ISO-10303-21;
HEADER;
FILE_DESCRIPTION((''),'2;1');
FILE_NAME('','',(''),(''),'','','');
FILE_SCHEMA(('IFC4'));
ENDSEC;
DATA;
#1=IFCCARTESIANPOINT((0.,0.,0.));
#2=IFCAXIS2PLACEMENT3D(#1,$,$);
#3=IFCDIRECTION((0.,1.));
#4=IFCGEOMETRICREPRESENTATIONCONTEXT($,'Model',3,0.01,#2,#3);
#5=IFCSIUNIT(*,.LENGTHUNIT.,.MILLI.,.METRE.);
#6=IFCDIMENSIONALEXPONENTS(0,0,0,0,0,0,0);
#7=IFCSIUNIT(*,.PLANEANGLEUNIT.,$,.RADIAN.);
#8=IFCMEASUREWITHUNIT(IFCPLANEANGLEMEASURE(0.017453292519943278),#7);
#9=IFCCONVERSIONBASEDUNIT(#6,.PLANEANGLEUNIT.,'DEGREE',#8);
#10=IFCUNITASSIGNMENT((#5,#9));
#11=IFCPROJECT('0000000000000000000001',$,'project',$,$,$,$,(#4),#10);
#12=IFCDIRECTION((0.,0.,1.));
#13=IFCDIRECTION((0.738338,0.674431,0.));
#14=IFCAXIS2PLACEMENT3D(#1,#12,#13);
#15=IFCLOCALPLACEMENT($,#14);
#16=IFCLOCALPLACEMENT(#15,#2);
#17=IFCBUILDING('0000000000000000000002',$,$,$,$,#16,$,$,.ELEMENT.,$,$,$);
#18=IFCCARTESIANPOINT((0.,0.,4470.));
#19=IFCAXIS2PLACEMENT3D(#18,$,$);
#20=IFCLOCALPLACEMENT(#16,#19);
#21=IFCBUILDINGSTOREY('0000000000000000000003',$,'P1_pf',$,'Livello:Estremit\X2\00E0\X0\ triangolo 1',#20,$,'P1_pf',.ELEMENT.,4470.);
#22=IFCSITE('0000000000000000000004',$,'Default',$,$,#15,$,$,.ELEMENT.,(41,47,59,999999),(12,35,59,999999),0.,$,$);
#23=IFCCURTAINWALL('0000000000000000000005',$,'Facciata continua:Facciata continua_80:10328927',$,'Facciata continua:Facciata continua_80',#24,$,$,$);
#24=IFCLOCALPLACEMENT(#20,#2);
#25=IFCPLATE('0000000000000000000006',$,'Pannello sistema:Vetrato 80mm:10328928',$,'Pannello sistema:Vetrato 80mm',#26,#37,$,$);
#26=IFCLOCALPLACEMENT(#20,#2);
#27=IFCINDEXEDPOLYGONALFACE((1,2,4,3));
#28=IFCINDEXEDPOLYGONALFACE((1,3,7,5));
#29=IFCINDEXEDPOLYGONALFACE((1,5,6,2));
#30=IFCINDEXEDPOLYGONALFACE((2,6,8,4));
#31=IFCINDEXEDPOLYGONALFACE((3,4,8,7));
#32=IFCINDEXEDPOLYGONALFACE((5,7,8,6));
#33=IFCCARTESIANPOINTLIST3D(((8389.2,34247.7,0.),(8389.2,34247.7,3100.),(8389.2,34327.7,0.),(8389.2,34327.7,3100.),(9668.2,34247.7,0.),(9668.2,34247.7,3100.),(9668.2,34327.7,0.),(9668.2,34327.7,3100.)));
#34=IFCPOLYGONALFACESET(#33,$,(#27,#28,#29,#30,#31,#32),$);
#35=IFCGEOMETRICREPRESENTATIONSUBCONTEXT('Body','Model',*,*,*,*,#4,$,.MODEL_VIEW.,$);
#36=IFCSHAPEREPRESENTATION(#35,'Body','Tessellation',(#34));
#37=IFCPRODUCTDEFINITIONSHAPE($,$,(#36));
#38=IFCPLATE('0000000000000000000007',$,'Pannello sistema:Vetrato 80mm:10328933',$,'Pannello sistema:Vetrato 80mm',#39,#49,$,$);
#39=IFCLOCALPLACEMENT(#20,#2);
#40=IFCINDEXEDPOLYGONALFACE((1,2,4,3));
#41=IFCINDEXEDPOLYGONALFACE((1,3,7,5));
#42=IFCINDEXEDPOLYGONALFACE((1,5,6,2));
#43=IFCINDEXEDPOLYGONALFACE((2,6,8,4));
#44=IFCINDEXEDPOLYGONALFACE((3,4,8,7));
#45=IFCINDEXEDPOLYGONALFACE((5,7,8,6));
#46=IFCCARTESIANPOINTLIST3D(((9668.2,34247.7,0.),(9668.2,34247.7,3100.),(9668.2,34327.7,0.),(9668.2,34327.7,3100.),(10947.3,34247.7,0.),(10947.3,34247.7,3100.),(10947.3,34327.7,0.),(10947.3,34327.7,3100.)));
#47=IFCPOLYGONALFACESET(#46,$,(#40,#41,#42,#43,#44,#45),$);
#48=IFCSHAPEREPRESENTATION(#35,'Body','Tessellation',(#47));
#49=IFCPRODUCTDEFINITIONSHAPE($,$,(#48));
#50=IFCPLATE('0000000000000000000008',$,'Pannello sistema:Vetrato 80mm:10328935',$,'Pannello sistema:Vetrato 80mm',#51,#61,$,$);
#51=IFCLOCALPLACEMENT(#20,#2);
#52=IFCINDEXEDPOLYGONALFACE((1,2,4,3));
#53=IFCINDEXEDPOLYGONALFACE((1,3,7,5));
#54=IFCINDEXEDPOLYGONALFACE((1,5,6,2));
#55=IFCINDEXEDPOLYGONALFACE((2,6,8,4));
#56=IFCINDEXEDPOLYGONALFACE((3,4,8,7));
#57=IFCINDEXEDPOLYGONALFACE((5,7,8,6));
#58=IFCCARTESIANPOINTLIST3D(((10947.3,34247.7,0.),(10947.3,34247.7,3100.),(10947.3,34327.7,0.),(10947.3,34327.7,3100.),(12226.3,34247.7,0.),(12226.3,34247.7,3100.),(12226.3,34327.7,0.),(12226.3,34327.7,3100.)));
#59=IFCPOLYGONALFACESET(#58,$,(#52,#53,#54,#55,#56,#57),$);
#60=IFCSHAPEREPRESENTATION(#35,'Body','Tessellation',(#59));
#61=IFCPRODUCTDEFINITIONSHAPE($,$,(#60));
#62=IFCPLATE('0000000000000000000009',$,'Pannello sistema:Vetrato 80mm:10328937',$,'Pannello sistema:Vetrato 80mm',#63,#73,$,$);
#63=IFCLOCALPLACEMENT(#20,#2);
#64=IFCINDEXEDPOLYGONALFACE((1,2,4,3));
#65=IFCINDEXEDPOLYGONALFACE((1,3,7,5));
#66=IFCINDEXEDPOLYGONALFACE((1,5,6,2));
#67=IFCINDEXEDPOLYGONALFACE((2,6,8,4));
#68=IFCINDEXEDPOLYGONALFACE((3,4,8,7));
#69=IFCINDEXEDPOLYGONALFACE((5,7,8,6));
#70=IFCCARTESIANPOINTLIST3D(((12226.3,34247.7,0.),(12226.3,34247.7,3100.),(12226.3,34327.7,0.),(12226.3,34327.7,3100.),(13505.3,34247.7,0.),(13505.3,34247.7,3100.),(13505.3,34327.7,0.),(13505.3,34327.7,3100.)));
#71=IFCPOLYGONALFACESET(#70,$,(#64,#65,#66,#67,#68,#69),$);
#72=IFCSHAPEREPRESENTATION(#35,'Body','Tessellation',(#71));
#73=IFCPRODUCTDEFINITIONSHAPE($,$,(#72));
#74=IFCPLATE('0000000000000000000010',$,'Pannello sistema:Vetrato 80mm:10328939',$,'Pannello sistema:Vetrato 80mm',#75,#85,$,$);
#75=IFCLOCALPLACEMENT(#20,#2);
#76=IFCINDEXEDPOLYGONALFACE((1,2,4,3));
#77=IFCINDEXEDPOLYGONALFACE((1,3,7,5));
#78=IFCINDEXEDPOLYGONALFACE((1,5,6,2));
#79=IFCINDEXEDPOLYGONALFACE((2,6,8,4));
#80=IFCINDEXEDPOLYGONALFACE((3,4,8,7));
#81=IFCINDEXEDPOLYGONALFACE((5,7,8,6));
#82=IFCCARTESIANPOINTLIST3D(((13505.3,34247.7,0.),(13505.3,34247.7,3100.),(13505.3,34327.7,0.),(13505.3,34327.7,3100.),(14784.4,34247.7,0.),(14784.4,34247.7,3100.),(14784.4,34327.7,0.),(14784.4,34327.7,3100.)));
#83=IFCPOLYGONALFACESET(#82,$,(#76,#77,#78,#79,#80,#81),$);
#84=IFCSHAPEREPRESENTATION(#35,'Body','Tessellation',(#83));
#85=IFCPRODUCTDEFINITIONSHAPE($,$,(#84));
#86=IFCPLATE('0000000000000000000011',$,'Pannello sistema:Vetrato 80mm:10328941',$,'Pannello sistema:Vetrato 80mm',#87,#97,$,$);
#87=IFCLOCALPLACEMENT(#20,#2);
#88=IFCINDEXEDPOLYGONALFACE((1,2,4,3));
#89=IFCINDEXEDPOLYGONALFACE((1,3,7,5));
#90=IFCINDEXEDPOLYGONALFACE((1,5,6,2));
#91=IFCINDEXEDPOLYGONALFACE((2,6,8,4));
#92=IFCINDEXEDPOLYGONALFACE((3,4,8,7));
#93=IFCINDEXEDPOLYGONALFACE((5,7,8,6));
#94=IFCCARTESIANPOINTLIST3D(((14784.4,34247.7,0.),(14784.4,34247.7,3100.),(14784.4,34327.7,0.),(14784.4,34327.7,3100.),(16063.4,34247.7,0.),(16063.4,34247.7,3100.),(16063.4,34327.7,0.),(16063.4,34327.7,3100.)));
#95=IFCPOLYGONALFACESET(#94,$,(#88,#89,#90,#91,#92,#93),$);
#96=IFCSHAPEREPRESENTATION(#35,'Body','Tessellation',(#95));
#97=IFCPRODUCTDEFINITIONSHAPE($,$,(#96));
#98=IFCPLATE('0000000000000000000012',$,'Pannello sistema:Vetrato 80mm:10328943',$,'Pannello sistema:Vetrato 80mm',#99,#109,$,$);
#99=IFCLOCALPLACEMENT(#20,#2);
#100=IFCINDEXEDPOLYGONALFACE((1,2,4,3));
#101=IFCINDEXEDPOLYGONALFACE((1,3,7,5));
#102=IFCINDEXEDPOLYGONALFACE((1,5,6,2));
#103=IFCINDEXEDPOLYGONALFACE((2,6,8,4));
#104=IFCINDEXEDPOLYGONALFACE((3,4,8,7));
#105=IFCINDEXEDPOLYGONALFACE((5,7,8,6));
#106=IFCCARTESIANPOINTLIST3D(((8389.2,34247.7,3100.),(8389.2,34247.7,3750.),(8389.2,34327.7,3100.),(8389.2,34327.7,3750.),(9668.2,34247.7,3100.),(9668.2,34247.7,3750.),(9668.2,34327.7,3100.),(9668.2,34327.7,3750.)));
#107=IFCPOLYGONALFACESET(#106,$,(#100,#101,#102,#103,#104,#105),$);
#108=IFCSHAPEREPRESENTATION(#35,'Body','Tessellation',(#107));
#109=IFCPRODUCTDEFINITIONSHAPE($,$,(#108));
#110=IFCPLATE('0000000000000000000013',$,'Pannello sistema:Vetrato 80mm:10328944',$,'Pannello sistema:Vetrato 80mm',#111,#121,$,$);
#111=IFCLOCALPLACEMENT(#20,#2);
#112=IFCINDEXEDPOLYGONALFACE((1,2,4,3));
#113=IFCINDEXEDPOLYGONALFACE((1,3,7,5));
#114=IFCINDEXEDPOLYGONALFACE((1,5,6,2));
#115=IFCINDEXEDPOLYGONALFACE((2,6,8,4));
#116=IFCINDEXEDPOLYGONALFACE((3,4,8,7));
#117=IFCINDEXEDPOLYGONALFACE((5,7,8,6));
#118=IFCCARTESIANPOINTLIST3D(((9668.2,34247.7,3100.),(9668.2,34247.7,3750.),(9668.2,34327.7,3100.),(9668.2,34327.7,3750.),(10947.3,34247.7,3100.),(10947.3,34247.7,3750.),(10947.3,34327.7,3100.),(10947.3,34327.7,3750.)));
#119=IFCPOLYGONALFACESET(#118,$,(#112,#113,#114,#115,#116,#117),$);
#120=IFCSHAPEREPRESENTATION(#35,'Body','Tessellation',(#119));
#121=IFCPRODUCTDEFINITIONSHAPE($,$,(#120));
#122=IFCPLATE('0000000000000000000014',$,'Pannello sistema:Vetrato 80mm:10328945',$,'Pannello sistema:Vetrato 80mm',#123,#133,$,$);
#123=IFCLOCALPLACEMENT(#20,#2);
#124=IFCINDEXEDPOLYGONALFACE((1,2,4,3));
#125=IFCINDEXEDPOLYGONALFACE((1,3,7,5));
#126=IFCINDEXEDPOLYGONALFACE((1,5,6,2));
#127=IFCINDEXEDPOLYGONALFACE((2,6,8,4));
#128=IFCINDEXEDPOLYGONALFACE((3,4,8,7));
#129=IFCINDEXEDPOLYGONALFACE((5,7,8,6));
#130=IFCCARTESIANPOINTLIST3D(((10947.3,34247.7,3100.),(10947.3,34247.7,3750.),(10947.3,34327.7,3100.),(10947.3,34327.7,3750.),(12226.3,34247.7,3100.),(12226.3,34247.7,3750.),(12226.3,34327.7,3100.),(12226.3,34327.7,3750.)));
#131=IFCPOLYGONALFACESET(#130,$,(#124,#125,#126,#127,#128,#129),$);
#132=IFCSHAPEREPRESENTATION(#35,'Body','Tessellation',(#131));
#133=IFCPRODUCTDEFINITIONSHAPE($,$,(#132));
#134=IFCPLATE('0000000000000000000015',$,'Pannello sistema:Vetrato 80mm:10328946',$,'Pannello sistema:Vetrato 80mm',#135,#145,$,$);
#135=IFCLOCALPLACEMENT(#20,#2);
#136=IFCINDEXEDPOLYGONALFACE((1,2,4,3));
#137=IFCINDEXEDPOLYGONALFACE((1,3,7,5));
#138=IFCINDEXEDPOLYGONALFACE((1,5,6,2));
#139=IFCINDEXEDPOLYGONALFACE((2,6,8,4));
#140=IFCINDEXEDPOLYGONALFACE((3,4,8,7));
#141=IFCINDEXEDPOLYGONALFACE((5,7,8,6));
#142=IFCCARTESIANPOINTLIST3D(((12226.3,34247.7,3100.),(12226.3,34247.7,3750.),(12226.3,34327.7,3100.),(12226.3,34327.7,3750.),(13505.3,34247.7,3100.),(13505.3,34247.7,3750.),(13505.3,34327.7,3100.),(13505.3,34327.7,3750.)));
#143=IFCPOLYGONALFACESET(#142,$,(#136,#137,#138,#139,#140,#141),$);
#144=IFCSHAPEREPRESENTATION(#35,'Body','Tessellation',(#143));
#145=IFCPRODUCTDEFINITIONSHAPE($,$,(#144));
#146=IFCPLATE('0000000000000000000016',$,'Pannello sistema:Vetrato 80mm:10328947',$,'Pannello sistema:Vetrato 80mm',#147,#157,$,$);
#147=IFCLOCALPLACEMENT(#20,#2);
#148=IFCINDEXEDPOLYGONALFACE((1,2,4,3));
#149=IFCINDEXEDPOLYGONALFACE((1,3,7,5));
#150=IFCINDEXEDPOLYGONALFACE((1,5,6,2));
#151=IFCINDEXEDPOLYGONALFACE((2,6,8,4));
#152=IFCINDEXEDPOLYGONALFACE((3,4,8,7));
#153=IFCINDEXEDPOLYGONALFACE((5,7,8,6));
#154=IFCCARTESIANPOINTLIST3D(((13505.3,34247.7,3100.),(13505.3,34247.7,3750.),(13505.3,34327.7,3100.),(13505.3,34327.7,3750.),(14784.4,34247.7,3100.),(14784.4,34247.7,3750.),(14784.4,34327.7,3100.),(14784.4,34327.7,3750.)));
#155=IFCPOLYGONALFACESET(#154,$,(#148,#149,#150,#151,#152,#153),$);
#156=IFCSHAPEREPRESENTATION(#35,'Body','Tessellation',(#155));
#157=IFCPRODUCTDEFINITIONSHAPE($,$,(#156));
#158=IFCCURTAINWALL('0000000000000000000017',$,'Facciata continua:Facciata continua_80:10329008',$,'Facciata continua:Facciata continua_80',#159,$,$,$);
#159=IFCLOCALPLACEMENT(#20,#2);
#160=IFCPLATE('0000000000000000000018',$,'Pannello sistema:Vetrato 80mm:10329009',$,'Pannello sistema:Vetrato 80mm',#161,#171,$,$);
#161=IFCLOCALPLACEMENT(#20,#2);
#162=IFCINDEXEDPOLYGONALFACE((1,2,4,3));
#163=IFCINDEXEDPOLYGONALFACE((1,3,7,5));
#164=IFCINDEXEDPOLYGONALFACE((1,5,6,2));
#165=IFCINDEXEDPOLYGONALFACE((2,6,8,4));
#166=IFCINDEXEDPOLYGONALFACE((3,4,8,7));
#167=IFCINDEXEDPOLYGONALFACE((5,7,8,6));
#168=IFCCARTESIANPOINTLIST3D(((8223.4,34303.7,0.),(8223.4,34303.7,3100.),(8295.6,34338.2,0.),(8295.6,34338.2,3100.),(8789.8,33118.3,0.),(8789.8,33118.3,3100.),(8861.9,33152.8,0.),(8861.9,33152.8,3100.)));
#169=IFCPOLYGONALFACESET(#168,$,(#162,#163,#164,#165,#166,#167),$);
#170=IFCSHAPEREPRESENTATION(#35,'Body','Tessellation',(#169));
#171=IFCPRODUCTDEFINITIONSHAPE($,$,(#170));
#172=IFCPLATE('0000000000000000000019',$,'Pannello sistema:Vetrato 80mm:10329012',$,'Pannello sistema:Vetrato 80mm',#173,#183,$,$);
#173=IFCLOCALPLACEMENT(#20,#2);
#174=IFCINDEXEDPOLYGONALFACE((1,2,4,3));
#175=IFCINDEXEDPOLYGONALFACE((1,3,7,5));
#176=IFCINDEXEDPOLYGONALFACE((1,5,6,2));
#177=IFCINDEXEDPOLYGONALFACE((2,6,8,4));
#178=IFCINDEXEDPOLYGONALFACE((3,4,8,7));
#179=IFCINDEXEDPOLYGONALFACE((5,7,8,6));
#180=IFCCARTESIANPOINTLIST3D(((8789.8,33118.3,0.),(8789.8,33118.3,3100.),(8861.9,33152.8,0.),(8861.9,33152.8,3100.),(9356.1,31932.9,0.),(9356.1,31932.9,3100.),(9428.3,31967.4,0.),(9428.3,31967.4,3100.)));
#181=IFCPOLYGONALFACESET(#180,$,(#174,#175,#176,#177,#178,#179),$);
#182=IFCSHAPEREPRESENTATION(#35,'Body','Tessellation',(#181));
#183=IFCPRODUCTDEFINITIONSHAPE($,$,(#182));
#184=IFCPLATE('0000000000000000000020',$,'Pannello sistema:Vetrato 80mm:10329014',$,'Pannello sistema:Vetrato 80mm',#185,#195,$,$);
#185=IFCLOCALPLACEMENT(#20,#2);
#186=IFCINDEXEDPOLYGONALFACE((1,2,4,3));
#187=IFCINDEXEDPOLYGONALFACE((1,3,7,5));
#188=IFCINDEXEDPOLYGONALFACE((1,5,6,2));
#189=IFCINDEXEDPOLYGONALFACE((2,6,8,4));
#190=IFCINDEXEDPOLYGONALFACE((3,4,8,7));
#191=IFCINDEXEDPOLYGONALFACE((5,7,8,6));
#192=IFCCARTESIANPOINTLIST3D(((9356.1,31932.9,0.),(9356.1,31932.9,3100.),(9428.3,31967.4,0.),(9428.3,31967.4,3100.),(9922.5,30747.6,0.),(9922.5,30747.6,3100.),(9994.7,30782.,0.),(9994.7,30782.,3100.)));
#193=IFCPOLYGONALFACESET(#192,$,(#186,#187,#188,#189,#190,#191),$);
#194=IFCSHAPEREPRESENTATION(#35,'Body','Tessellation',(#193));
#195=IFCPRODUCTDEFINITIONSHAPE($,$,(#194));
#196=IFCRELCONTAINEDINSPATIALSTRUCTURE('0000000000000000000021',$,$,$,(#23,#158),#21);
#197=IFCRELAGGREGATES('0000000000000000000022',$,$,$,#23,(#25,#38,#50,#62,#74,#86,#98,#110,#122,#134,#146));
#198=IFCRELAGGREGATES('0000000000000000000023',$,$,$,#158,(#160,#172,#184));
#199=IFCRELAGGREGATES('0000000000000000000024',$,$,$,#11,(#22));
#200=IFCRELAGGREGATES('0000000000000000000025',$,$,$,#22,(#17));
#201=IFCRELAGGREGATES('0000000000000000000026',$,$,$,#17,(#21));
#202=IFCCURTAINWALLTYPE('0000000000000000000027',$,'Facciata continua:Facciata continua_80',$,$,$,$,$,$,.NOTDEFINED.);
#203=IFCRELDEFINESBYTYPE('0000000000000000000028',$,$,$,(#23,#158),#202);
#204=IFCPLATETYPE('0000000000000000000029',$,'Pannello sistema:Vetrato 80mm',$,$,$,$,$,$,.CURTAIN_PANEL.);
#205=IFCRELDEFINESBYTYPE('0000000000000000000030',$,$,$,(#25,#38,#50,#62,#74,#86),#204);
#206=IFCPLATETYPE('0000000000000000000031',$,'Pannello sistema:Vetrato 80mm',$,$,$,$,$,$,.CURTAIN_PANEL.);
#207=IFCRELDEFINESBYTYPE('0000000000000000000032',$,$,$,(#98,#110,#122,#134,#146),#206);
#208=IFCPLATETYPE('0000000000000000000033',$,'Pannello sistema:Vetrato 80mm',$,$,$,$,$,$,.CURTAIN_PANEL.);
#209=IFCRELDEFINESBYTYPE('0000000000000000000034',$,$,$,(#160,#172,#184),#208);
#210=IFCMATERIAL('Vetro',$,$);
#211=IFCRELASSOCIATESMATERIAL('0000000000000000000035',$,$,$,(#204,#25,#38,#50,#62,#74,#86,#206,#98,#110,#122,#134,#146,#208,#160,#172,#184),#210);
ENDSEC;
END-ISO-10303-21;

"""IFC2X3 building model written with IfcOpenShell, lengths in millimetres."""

from ifc_helpers import new_model, entity, si_unit, converted_unit, direction, frame, frame_2d, origin, origin_2d_with_axis, place, context, subcontext, project, spatial, rectangle, extrude, source, transform, mapped, material, type_object, type_shapes, element, aggregate, save


model = new_model("IFC2X3")

# Units and contexts
model_context = context("Model", 3, precision=0.01, world=origin(), true_north=direction((0.0, 1.0)))
body_context = subcontext(model_context, "Body", "Model", "MODEL_VIEW")
ifc_project = project(units=[si_unit("LENGTHUNIT", "METRE", prefix="MILLI"), converted_unit("PLANEANGLEUNIT", "DEGREE", entity("IfcPlaneAngleMeasure", 0.017453292519943278), si_unit("PLANEANGLEUNIT", "RADIAN"), dimensions=[0, 0, 0, 0, 0, 0, 0])], contexts=[model_context])

# Site, building, storey
site_placement = place(None, frame((0.0, 0.0, 0.0), z_axis=(0.0, 0.0, 1.0), x_axis=(0.738338, 0.674431, 0.0)))
site = spatial("IfcSite", under=ifc_project, at=site_placement, Name="Default", CompositionType="ELEMENT", RefLatitude=(41, 47, 59, 999999), RefLongitude=(12, 35, 59, 999999), RefElevation=0.0)
building_placement = place(site_placement, origin())
building = spatial("IfcBuilding", under=site, at=building_placement, CompositionType="ELEMENT")
storey_placement = place(building_placement, frame((0.0, 0.0, 4470.0)))
storey = spatial("IfcBuildingStorey", under=building, at=storey_placement, Name="P1_pf", ObjectType="Livello:Estremità triangolo 1", LongName="P1_pf", CompositionType="ELEMENT", Elevation=4470.0)

# Curtain walls, plates
curtain_wall_type = type_object("IfcCurtainWallType", Name="Facciata continua:Facciata continua_80", PredefinedType="NOTDEFINED")
curtain_wall_1_placement = place(storey_placement, frame((0.0, 0.0, -4470.0)))
curtain_wall_1 = element("IfcCurtainWall", 1, at=curtain_wall_1_placement, inside=storey, type_object=curtain_wall_type, Name="Facciata continua:Facciata continua_80:10328927", ObjectType="Facciata continua:Facciata continua_80")
ifc_material_1 = material(Name="Vetro")
plate_type_1 = type_object("IfcPlateType", Name="Pannello sistema:Vetrato 80mm", PredefinedType="CURTAIN_PANEL", material=ifc_material_1)
shared_shape_1 = source(origin(), body_context, "Body", "SweptSolid", [
    extrude(rectangle(XDim=80.0, YDim=1279.0, at=origin_2d_with_axis()), frame((0.0, -40.0, 0.0), z_axis=(0.0, 0.0, 1.0), x_axis=(0.0, 1.0, 0.0)), (0.0, 0.0, 1.0), 3100.0),
])
type_shapes(plate_type_1, [shared_shape_1])
plate_1_placement = place(curtain_wall_1_placement, frame((9028.7, 34327.7, 4470.0)))
plate_1 = element("IfcPlate", 2, at=plate_1_placement, type_object=plate_type_1, material=ifc_material_1, Name="Pannello sistema:Vetrato 80mm:10328928", ObjectType="Pannello sistema:Vetrato 80mm", context=body_context, shape_type="MappedRepresentation", body=[
    mapped(shared_shape_1, transform((0.0, 0.0, 0.0), scale=1.0)),
])
plate_2_placement = place(curtain_wall_1_placement, frame((10307.7, 34327.7, 4470.0)))
plate_2 = element("IfcPlate", 3, at=plate_2_placement, type_object=plate_type_1, material=ifc_material_1, Name="Pannello sistema:Vetrato 80mm:10328933", ObjectType="Pannello sistema:Vetrato 80mm", context=body_context, shape_type="MappedRepresentation", body=[
    mapped(shared_shape_1, transform((0.0, 0.0, 0.0), scale=1.0)),
])
plate_3_placement = place(curtain_wall_1_placement, frame((11586.8, 34327.7, 4470.0)))
plate_3 = element("IfcPlate", 4, at=plate_3_placement, type_object=plate_type_1, material=ifc_material_1, Name="Pannello sistema:Vetrato 80mm:10328935", ObjectType="Pannello sistema:Vetrato 80mm", context=body_context, shape_type="MappedRepresentation", body=[
    mapped(shared_shape_1, transform((0.0, 0.0, 0.0), scale=1.0)),
])
plate_4_placement = place(curtain_wall_1_placement, frame((12865.8, 34327.7, 4470.0)))
plate_4 = element("IfcPlate", 5, at=plate_4_placement, type_object=plate_type_1, material=ifc_material_1, Name="Pannello sistema:Vetrato 80mm:10328937", ObjectType="Pannello sistema:Vetrato 80mm", context=body_context, shape_type="MappedRepresentation", body=[
    mapped(shared_shape_1, transform((0.0, 0.0, 0.0), scale=1.0)),
])
plate_5_placement = place(curtain_wall_1_placement, frame((14144.9, 34327.7, 4470.0)))
plate_5 = element("IfcPlate", 6, at=plate_5_placement, type_object=plate_type_1, material=ifc_material_1, Name="Pannello sistema:Vetrato 80mm:10328939", ObjectType="Pannello sistema:Vetrato 80mm", context=body_context, shape_type="MappedRepresentation", body=[
    mapped(shared_shape_1, transform((0.0, 0.0, 0.0), scale=1.0)),
])
plate_6_placement = place(curtain_wall_1_placement, frame((15423.9, 34327.7, 4470.0)))
plate_6 = element("IfcPlate", 7, at=plate_6_placement, type_object=plate_type_1, material=ifc_material_1, Name="Pannello sistema:Vetrato 80mm:10328941", ObjectType="Pannello sistema:Vetrato 80mm", context=body_context, shape_type="MappedRepresentation", body=[
    mapped(shared_shape_1, transform((0.0, 0.0, 0.0), scale=1.0)),
])
plate_type_2 = type_object("IfcPlateType", Name="Pannello sistema:Vetrato 80mm", PredefinedType="CURTAIN_PANEL", material=ifc_material_1)
shared_shape_2 = source(origin(), body_context, "Body", "SweptSolid", [
    extrude(rectangle(XDim=80.0, YDim=1279.0, at=origin_2d_with_axis()), frame((0.0, -40.0, 0.0), z_axis=(0.0, 0.0, 1.0), x_axis=(0.0, 1.0, 0.0)), (0.0, 0.0, 1.0), 650.0),
])
type_shapes(plate_type_2, [shared_shape_2])
plate_7_placement = place(curtain_wall_1_placement, frame((9028.7, 34327.7, 7570.0)))
plate_7 = element("IfcPlate", 8, at=plate_7_placement, type_object=plate_type_2, material=ifc_material_1, Name="Pannello sistema:Vetrato 80mm:10328943", ObjectType="Pannello sistema:Vetrato 80mm", context=body_context, shape_type="MappedRepresentation", body=[
    mapped(shared_shape_2, transform((0.0, 0.0, 0.0), scale=1.0)),
])
plate_8_placement = place(curtain_wall_1_placement, frame((10307.7, 34327.7, 7570.0)))
plate_8 = element("IfcPlate", 9, at=plate_8_placement, type_object=plate_type_2, material=ifc_material_1, Name="Pannello sistema:Vetrato 80mm:10328944", ObjectType="Pannello sistema:Vetrato 80mm", context=body_context, shape_type="MappedRepresentation", body=[
    mapped(shared_shape_2, transform((0.0, 0.0, 0.0), scale=1.0)),
])
plate_9_placement = place(curtain_wall_1_placement, frame((11586.8, 34327.7, 7570.0)))
plate_9 = element("IfcPlate", 10, at=plate_9_placement, type_object=plate_type_2, material=ifc_material_1, Name="Pannello sistema:Vetrato 80mm:10328945", ObjectType="Pannello sistema:Vetrato 80mm", context=body_context, shape_type="MappedRepresentation", body=[
    mapped(shared_shape_2, transform((0.0, 0.0, 0.0), scale=1.0)),
])
plate_10_placement = place(curtain_wall_1_placement, frame((12865.8, 34327.7, 7570.0)))
plate_10 = element("IfcPlate", 11, at=plate_10_placement, type_object=plate_type_2, material=ifc_material_1, Name="Pannello sistema:Vetrato 80mm:10328946", ObjectType="Pannello sistema:Vetrato 80mm", context=body_context, shape_type="MappedRepresentation", body=[
    mapped(shared_shape_2, transform((0.0, 0.0, 0.0), scale=1.0)),
])
plate_11_placement = place(curtain_wall_1_placement, frame((14144.9, 34327.7, 7570.0)))
plate_11 = element("IfcPlate", 12, at=plate_11_placement, type_object=plate_type_2, material=ifc_material_1, Name="Pannello sistema:Vetrato 80mm:10328947", ObjectType="Pannello sistema:Vetrato 80mm", context=body_context, shape_type="MappedRepresentation", body=[
    mapped(shared_shape_2, transform((0.0, 0.0, 0.0), scale=1.0)),
])
aggregate(curtain_wall_1, [plate_1, plate_2, plate_3, plate_4, plate_5, plate_6, plate_7, plate_8, plate_9, plate_10, plate_11])
curtain_wall_2_placement = place(storey_placement, frame((0.0, 0.0, -4470.0)))
curtain_wall_2 = element("IfcCurtainWall", 13, at=curtain_wall_2_placement, inside=storey, type_object=curtain_wall_type, Name="Facciata continua:Facciata continua_80:10329008", ObjectType="Facciata continua:Facciata continua_80")
plate_type_3 = type_object("IfcPlateType", Name="Pannello sistema:Vetrato 80mm", PredefinedType="CURTAIN_PANEL", material=ifc_material_1)
shared_shape_3 = source(origin(), body_context, "Body", "SweptSolid", [
    extrude(rectangle(XDim=80.0, YDim=1313.7, at=frame_2d((0.0, 0.0), x_axis=(1.0, 0.0))), frame((0.0, -40.0, 0.0), z_axis=(0.0, 0.0, 1.0), x_axis=(0.0, 1.0, 0.0)), (0.0, 0.0, 1.0), 3100.0),
])
type_shapes(plate_type_3, [shared_shape_3])
plate_12_placement = place(curtain_wall_2_placement, frame((8578.8, 33745.5, 4470.0), z_axis=(0.0, 0.0, 1.0), x_axis=(0.431105, -0.902302, 0.0)))
plate_12 = element("IfcPlate", 14, at=plate_12_placement, type_object=plate_type_3, material=ifc_material_1, Name="Pannello sistema:Vetrato 80mm:10329009", ObjectType="Pannello sistema:Vetrato 80mm", context=body_context, shape_type="MappedRepresentation", body=[
    mapped(shared_shape_3, transform((0.0, 0.0, 0.0), scale=1.0)),
])
plate_13_placement = place(curtain_wall_2_placement, frame((9145.1, 32560.1, 4470.0), z_axis=(0.0, 0.0, 1.0), x_axis=(0.431105, -0.902302, 0.0)))
plate_13 = element("IfcPlate", 15, at=plate_13_placement, type_object=plate_type_3, material=ifc_material_1, Name="Pannello sistema:Vetrato 80mm:10329012", ObjectType="Pannello sistema:Vetrato 80mm", context=body_context, shape_type="MappedRepresentation", body=[
    mapped(shared_shape_3, transform((0.0, 0.0, 0.0), scale=1.0)),
])
plate_14_placement = place(curtain_wall_2_placement, frame((9711.5, 31374.7, 4470.0), z_axis=(0.0, 0.0, 1.0), x_axis=(0.431105, -0.902302, 0.0)))
plate_14 = element("IfcPlate", 16, at=plate_14_placement, type_object=plate_type_3, material=ifc_material_1, Name="Pannello sistema:Vetrato 80mm:10329014", ObjectType="Pannello sistema:Vetrato 80mm", context=body_context, shape_type="MappedRepresentation", body=[
    mapped(shared_shape_3, transform((0.0, 0.0, 0.0), scale=1.0)),
])
aggregate(curtain_wall_2, [plate_12, plate_13, plate_14])

save(model, "model.ifc")
